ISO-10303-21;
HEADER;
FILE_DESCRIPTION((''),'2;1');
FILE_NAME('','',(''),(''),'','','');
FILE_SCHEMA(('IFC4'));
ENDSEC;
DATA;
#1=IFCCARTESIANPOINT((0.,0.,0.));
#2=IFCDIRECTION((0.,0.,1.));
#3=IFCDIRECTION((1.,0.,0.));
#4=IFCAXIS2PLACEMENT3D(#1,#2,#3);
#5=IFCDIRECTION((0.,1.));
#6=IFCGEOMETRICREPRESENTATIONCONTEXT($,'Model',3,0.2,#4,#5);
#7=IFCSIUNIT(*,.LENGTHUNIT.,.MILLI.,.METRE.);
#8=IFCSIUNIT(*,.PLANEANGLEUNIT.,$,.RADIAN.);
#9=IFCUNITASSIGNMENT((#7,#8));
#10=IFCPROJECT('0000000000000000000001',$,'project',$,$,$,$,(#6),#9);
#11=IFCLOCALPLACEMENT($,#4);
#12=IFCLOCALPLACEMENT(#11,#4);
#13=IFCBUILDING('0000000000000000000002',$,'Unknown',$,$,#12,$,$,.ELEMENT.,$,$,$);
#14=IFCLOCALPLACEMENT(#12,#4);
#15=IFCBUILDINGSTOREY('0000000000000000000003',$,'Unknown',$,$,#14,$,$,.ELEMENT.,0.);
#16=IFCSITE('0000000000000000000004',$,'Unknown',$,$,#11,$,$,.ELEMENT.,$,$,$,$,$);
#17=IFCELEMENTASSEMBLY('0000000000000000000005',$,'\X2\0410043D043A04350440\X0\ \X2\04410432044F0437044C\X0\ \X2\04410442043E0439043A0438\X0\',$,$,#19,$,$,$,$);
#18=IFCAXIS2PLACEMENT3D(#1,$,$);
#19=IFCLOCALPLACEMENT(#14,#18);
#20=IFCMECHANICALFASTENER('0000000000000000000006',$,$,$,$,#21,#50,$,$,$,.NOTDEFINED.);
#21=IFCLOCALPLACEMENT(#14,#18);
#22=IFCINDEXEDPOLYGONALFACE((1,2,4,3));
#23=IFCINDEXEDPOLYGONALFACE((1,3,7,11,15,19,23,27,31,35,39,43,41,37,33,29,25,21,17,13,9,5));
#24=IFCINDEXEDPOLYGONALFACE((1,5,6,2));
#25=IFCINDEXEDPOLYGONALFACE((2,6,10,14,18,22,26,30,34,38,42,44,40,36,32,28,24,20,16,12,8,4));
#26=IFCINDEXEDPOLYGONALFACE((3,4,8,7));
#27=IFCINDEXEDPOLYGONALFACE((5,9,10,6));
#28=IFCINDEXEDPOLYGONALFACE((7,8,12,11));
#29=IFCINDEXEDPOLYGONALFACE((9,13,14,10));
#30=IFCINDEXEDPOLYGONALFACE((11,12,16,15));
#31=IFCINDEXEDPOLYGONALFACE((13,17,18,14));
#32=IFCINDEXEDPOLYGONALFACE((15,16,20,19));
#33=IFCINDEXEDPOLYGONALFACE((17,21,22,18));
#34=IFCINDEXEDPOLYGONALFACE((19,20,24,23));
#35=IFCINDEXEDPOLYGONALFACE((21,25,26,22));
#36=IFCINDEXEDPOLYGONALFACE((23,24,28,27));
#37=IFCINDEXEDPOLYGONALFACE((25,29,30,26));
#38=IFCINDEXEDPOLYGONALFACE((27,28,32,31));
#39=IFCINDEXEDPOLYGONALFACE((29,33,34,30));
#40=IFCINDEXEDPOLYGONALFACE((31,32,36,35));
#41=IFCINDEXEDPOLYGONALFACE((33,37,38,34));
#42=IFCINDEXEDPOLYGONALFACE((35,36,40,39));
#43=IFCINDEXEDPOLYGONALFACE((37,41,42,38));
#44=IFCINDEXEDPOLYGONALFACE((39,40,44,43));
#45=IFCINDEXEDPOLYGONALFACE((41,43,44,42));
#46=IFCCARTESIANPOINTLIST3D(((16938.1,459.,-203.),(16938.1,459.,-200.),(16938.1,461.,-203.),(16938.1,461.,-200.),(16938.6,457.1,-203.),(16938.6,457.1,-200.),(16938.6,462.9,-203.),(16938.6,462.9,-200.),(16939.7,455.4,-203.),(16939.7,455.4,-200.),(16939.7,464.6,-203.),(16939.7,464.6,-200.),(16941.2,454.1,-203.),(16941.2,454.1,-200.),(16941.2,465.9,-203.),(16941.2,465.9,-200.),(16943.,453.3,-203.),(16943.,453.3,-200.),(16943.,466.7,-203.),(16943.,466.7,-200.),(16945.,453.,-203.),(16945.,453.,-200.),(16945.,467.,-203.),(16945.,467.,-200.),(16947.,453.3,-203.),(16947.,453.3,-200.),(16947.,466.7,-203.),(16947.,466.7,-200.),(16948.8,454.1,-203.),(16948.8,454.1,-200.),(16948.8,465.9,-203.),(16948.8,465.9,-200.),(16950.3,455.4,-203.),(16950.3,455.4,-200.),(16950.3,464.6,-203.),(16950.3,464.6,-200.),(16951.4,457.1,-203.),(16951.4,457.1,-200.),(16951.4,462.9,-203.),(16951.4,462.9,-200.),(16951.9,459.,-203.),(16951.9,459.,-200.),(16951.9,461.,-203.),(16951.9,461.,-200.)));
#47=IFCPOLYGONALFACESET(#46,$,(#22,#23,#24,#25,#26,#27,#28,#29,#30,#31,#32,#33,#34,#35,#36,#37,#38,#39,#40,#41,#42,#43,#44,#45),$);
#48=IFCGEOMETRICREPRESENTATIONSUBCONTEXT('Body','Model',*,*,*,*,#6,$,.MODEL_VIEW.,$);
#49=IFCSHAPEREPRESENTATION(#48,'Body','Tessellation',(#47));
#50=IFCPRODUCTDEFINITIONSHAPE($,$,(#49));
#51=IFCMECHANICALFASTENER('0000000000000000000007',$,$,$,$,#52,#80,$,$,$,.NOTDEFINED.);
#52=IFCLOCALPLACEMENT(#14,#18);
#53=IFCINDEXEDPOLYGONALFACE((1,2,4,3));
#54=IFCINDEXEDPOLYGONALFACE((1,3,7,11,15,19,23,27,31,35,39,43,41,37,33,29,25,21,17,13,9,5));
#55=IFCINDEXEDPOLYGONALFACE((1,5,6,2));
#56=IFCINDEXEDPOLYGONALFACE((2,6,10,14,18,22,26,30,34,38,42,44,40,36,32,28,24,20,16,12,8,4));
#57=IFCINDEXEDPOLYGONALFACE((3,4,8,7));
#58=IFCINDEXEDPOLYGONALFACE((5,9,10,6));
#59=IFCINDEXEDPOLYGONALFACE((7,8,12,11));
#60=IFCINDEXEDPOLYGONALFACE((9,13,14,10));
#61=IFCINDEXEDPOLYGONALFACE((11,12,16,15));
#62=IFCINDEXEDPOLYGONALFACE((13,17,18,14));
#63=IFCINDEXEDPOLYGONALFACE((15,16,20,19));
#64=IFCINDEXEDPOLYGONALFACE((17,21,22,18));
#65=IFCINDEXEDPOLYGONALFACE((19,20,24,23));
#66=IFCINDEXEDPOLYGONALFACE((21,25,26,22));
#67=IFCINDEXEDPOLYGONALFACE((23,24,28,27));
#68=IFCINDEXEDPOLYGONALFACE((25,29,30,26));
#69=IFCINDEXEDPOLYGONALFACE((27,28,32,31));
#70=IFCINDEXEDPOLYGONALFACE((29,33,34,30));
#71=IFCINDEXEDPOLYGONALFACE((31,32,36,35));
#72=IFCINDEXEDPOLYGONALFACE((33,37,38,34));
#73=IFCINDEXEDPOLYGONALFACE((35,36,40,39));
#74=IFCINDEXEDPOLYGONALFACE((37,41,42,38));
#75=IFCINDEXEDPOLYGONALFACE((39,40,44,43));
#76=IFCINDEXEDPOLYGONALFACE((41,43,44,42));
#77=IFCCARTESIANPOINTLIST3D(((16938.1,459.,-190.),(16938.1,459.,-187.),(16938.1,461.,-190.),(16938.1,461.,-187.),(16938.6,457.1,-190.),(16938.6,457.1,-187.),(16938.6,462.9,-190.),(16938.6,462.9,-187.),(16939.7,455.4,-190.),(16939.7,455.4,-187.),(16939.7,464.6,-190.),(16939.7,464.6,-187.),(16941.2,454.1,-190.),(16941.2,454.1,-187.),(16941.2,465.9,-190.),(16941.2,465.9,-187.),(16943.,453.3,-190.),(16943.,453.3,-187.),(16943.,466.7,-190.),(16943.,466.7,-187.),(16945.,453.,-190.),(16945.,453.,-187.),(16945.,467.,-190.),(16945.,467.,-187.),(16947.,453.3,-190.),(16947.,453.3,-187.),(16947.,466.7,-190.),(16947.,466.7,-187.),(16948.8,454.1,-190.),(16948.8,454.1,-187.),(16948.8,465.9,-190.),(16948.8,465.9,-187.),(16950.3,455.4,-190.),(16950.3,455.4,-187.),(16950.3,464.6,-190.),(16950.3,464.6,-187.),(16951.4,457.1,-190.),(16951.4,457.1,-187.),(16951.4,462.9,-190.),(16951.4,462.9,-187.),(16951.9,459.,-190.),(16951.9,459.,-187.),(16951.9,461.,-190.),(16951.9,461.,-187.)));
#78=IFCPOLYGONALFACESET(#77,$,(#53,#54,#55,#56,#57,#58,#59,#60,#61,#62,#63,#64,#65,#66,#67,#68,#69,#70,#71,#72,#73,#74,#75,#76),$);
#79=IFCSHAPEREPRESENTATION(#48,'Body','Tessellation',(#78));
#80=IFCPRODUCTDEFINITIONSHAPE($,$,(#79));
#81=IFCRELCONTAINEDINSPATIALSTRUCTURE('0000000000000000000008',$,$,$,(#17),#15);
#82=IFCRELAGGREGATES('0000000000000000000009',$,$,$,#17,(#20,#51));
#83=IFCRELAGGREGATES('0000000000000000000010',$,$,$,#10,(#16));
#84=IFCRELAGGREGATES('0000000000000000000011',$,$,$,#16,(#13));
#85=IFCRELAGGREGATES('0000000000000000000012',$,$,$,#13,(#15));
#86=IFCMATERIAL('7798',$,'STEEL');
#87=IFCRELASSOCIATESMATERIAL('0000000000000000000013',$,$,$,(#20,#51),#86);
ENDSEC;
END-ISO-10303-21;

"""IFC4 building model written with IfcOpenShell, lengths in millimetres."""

from ifc_helpers import new_model, si_unit, direction, frame, origin_with_axes, place, context, subcontext, project, spatial, arc, indexed_curve, outline, extrude, source, transform, mapped, material, element, aggregate, save


model = new_model("IFC4")

# Units and contexts
model_context = context("Model", 3, precision=0.2, world=origin_with_axes(), true_north=direction((0.0, 1.0)))
body_context = subcontext(model_context, "Body", "Model", "MODEL_VIEW")
ifc_project = project(units=[si_unit("LENGTHUNIT", "METRE", prefix="MILLI"), si_unit("PLANEANGLEUNIT", "RADIAN")], contexts=[model_context])

# Site, building, storey
site_placement = place(None, origin_with_axes())
site = spatial("IfcSite", under=ifc_project, at=site_placement, Name="Unknown", CompositionType="ELEMENT")
building_placement = place(site_placement, origin_with_axes())
building = spatial("IfcBuilding", under=site, at=building_placement, Name="Unknown", CompositionType="ELEMENT")
storey_placement = place(building_placement, origin_with_axes())
storey = spatial("IfcBuildingStorey", under=building, at=storey_placement, Name="Unknown", CompositionType="ELEMENT", Elevation=0.0)

# Element assembly
assembly_1_placement = place(storey_placement, frame((16945.0, 460.0, -160.0), z_axis=(0.0, -1.0, 0.0), x_axis=(0.0, 0.0, -1.0)))
assembly_1 = element("IfcElementAssembly", 1, at=assembly_1_placement, inside=storey, Name="Анкер связь стойки")

# Mechanical fasteners
ifc_material_1 = material(Name="7798", Category="STEEL")
shared_shape_1 = source(origin_with_axes(), body_context, "Body", "SweptSolid", [
    extrude(outline(indexed_curve([(7.0, 0.0), (0.0, 7.0), (-7.0, 0.0), (0.0, -7.0)], segments=[arc(1, 2, 3), arc(3, 4, 1)])), frame((0.0, 0.0, 3.0), z_axis=(0.0, 0.0, -1.0), x_axis=(0.0, 1.0, 0.0)), (0.0, 0.0, 1.0), 3.0),
])
mechanical_fastener_1_placement = place(assembly_1_placement, frame((40.0, 0.0, 0.0), z_axis=(1.0, 0.0, 0.0), x_axis=(0.0, -1.0, 0.0)))
mechanical_fastener_1 = element("IfcMechanicalFastener", 2, at=mechanical_fastener_1_placement, material=ifc_material_1, PredefinedType="NOTDEFINED", context=body_context, shape_type="MappedRepresentation", body=[
    mapped(shared_shape_1, transform((0.0, 0.0, 0.0))),
])
mechanical_fastener_2_placement = place(assembly_1_placement, frame((27.0, 0.0, 0.0), z_axis=(1.0, 0.0, 0.0), x_axis=(0.0, -1.0, 0.0)))
mechanical_fastener_2 = element("IfcMechanicalFastener", 3, at=mechanical_fastener_2_placement, material=ifc_material_1, PredefinedType="NOTDEFINED", context=body_context, shape_type="MappedRepresentation", body=[
    mapped(shared_shape_1, transform((0.0, 0.0, 0.0))),
])
aggregate(assembly_1, [mechanical_fastener_1, mechanical_fastener_2])

save(model, "model.ifc")
